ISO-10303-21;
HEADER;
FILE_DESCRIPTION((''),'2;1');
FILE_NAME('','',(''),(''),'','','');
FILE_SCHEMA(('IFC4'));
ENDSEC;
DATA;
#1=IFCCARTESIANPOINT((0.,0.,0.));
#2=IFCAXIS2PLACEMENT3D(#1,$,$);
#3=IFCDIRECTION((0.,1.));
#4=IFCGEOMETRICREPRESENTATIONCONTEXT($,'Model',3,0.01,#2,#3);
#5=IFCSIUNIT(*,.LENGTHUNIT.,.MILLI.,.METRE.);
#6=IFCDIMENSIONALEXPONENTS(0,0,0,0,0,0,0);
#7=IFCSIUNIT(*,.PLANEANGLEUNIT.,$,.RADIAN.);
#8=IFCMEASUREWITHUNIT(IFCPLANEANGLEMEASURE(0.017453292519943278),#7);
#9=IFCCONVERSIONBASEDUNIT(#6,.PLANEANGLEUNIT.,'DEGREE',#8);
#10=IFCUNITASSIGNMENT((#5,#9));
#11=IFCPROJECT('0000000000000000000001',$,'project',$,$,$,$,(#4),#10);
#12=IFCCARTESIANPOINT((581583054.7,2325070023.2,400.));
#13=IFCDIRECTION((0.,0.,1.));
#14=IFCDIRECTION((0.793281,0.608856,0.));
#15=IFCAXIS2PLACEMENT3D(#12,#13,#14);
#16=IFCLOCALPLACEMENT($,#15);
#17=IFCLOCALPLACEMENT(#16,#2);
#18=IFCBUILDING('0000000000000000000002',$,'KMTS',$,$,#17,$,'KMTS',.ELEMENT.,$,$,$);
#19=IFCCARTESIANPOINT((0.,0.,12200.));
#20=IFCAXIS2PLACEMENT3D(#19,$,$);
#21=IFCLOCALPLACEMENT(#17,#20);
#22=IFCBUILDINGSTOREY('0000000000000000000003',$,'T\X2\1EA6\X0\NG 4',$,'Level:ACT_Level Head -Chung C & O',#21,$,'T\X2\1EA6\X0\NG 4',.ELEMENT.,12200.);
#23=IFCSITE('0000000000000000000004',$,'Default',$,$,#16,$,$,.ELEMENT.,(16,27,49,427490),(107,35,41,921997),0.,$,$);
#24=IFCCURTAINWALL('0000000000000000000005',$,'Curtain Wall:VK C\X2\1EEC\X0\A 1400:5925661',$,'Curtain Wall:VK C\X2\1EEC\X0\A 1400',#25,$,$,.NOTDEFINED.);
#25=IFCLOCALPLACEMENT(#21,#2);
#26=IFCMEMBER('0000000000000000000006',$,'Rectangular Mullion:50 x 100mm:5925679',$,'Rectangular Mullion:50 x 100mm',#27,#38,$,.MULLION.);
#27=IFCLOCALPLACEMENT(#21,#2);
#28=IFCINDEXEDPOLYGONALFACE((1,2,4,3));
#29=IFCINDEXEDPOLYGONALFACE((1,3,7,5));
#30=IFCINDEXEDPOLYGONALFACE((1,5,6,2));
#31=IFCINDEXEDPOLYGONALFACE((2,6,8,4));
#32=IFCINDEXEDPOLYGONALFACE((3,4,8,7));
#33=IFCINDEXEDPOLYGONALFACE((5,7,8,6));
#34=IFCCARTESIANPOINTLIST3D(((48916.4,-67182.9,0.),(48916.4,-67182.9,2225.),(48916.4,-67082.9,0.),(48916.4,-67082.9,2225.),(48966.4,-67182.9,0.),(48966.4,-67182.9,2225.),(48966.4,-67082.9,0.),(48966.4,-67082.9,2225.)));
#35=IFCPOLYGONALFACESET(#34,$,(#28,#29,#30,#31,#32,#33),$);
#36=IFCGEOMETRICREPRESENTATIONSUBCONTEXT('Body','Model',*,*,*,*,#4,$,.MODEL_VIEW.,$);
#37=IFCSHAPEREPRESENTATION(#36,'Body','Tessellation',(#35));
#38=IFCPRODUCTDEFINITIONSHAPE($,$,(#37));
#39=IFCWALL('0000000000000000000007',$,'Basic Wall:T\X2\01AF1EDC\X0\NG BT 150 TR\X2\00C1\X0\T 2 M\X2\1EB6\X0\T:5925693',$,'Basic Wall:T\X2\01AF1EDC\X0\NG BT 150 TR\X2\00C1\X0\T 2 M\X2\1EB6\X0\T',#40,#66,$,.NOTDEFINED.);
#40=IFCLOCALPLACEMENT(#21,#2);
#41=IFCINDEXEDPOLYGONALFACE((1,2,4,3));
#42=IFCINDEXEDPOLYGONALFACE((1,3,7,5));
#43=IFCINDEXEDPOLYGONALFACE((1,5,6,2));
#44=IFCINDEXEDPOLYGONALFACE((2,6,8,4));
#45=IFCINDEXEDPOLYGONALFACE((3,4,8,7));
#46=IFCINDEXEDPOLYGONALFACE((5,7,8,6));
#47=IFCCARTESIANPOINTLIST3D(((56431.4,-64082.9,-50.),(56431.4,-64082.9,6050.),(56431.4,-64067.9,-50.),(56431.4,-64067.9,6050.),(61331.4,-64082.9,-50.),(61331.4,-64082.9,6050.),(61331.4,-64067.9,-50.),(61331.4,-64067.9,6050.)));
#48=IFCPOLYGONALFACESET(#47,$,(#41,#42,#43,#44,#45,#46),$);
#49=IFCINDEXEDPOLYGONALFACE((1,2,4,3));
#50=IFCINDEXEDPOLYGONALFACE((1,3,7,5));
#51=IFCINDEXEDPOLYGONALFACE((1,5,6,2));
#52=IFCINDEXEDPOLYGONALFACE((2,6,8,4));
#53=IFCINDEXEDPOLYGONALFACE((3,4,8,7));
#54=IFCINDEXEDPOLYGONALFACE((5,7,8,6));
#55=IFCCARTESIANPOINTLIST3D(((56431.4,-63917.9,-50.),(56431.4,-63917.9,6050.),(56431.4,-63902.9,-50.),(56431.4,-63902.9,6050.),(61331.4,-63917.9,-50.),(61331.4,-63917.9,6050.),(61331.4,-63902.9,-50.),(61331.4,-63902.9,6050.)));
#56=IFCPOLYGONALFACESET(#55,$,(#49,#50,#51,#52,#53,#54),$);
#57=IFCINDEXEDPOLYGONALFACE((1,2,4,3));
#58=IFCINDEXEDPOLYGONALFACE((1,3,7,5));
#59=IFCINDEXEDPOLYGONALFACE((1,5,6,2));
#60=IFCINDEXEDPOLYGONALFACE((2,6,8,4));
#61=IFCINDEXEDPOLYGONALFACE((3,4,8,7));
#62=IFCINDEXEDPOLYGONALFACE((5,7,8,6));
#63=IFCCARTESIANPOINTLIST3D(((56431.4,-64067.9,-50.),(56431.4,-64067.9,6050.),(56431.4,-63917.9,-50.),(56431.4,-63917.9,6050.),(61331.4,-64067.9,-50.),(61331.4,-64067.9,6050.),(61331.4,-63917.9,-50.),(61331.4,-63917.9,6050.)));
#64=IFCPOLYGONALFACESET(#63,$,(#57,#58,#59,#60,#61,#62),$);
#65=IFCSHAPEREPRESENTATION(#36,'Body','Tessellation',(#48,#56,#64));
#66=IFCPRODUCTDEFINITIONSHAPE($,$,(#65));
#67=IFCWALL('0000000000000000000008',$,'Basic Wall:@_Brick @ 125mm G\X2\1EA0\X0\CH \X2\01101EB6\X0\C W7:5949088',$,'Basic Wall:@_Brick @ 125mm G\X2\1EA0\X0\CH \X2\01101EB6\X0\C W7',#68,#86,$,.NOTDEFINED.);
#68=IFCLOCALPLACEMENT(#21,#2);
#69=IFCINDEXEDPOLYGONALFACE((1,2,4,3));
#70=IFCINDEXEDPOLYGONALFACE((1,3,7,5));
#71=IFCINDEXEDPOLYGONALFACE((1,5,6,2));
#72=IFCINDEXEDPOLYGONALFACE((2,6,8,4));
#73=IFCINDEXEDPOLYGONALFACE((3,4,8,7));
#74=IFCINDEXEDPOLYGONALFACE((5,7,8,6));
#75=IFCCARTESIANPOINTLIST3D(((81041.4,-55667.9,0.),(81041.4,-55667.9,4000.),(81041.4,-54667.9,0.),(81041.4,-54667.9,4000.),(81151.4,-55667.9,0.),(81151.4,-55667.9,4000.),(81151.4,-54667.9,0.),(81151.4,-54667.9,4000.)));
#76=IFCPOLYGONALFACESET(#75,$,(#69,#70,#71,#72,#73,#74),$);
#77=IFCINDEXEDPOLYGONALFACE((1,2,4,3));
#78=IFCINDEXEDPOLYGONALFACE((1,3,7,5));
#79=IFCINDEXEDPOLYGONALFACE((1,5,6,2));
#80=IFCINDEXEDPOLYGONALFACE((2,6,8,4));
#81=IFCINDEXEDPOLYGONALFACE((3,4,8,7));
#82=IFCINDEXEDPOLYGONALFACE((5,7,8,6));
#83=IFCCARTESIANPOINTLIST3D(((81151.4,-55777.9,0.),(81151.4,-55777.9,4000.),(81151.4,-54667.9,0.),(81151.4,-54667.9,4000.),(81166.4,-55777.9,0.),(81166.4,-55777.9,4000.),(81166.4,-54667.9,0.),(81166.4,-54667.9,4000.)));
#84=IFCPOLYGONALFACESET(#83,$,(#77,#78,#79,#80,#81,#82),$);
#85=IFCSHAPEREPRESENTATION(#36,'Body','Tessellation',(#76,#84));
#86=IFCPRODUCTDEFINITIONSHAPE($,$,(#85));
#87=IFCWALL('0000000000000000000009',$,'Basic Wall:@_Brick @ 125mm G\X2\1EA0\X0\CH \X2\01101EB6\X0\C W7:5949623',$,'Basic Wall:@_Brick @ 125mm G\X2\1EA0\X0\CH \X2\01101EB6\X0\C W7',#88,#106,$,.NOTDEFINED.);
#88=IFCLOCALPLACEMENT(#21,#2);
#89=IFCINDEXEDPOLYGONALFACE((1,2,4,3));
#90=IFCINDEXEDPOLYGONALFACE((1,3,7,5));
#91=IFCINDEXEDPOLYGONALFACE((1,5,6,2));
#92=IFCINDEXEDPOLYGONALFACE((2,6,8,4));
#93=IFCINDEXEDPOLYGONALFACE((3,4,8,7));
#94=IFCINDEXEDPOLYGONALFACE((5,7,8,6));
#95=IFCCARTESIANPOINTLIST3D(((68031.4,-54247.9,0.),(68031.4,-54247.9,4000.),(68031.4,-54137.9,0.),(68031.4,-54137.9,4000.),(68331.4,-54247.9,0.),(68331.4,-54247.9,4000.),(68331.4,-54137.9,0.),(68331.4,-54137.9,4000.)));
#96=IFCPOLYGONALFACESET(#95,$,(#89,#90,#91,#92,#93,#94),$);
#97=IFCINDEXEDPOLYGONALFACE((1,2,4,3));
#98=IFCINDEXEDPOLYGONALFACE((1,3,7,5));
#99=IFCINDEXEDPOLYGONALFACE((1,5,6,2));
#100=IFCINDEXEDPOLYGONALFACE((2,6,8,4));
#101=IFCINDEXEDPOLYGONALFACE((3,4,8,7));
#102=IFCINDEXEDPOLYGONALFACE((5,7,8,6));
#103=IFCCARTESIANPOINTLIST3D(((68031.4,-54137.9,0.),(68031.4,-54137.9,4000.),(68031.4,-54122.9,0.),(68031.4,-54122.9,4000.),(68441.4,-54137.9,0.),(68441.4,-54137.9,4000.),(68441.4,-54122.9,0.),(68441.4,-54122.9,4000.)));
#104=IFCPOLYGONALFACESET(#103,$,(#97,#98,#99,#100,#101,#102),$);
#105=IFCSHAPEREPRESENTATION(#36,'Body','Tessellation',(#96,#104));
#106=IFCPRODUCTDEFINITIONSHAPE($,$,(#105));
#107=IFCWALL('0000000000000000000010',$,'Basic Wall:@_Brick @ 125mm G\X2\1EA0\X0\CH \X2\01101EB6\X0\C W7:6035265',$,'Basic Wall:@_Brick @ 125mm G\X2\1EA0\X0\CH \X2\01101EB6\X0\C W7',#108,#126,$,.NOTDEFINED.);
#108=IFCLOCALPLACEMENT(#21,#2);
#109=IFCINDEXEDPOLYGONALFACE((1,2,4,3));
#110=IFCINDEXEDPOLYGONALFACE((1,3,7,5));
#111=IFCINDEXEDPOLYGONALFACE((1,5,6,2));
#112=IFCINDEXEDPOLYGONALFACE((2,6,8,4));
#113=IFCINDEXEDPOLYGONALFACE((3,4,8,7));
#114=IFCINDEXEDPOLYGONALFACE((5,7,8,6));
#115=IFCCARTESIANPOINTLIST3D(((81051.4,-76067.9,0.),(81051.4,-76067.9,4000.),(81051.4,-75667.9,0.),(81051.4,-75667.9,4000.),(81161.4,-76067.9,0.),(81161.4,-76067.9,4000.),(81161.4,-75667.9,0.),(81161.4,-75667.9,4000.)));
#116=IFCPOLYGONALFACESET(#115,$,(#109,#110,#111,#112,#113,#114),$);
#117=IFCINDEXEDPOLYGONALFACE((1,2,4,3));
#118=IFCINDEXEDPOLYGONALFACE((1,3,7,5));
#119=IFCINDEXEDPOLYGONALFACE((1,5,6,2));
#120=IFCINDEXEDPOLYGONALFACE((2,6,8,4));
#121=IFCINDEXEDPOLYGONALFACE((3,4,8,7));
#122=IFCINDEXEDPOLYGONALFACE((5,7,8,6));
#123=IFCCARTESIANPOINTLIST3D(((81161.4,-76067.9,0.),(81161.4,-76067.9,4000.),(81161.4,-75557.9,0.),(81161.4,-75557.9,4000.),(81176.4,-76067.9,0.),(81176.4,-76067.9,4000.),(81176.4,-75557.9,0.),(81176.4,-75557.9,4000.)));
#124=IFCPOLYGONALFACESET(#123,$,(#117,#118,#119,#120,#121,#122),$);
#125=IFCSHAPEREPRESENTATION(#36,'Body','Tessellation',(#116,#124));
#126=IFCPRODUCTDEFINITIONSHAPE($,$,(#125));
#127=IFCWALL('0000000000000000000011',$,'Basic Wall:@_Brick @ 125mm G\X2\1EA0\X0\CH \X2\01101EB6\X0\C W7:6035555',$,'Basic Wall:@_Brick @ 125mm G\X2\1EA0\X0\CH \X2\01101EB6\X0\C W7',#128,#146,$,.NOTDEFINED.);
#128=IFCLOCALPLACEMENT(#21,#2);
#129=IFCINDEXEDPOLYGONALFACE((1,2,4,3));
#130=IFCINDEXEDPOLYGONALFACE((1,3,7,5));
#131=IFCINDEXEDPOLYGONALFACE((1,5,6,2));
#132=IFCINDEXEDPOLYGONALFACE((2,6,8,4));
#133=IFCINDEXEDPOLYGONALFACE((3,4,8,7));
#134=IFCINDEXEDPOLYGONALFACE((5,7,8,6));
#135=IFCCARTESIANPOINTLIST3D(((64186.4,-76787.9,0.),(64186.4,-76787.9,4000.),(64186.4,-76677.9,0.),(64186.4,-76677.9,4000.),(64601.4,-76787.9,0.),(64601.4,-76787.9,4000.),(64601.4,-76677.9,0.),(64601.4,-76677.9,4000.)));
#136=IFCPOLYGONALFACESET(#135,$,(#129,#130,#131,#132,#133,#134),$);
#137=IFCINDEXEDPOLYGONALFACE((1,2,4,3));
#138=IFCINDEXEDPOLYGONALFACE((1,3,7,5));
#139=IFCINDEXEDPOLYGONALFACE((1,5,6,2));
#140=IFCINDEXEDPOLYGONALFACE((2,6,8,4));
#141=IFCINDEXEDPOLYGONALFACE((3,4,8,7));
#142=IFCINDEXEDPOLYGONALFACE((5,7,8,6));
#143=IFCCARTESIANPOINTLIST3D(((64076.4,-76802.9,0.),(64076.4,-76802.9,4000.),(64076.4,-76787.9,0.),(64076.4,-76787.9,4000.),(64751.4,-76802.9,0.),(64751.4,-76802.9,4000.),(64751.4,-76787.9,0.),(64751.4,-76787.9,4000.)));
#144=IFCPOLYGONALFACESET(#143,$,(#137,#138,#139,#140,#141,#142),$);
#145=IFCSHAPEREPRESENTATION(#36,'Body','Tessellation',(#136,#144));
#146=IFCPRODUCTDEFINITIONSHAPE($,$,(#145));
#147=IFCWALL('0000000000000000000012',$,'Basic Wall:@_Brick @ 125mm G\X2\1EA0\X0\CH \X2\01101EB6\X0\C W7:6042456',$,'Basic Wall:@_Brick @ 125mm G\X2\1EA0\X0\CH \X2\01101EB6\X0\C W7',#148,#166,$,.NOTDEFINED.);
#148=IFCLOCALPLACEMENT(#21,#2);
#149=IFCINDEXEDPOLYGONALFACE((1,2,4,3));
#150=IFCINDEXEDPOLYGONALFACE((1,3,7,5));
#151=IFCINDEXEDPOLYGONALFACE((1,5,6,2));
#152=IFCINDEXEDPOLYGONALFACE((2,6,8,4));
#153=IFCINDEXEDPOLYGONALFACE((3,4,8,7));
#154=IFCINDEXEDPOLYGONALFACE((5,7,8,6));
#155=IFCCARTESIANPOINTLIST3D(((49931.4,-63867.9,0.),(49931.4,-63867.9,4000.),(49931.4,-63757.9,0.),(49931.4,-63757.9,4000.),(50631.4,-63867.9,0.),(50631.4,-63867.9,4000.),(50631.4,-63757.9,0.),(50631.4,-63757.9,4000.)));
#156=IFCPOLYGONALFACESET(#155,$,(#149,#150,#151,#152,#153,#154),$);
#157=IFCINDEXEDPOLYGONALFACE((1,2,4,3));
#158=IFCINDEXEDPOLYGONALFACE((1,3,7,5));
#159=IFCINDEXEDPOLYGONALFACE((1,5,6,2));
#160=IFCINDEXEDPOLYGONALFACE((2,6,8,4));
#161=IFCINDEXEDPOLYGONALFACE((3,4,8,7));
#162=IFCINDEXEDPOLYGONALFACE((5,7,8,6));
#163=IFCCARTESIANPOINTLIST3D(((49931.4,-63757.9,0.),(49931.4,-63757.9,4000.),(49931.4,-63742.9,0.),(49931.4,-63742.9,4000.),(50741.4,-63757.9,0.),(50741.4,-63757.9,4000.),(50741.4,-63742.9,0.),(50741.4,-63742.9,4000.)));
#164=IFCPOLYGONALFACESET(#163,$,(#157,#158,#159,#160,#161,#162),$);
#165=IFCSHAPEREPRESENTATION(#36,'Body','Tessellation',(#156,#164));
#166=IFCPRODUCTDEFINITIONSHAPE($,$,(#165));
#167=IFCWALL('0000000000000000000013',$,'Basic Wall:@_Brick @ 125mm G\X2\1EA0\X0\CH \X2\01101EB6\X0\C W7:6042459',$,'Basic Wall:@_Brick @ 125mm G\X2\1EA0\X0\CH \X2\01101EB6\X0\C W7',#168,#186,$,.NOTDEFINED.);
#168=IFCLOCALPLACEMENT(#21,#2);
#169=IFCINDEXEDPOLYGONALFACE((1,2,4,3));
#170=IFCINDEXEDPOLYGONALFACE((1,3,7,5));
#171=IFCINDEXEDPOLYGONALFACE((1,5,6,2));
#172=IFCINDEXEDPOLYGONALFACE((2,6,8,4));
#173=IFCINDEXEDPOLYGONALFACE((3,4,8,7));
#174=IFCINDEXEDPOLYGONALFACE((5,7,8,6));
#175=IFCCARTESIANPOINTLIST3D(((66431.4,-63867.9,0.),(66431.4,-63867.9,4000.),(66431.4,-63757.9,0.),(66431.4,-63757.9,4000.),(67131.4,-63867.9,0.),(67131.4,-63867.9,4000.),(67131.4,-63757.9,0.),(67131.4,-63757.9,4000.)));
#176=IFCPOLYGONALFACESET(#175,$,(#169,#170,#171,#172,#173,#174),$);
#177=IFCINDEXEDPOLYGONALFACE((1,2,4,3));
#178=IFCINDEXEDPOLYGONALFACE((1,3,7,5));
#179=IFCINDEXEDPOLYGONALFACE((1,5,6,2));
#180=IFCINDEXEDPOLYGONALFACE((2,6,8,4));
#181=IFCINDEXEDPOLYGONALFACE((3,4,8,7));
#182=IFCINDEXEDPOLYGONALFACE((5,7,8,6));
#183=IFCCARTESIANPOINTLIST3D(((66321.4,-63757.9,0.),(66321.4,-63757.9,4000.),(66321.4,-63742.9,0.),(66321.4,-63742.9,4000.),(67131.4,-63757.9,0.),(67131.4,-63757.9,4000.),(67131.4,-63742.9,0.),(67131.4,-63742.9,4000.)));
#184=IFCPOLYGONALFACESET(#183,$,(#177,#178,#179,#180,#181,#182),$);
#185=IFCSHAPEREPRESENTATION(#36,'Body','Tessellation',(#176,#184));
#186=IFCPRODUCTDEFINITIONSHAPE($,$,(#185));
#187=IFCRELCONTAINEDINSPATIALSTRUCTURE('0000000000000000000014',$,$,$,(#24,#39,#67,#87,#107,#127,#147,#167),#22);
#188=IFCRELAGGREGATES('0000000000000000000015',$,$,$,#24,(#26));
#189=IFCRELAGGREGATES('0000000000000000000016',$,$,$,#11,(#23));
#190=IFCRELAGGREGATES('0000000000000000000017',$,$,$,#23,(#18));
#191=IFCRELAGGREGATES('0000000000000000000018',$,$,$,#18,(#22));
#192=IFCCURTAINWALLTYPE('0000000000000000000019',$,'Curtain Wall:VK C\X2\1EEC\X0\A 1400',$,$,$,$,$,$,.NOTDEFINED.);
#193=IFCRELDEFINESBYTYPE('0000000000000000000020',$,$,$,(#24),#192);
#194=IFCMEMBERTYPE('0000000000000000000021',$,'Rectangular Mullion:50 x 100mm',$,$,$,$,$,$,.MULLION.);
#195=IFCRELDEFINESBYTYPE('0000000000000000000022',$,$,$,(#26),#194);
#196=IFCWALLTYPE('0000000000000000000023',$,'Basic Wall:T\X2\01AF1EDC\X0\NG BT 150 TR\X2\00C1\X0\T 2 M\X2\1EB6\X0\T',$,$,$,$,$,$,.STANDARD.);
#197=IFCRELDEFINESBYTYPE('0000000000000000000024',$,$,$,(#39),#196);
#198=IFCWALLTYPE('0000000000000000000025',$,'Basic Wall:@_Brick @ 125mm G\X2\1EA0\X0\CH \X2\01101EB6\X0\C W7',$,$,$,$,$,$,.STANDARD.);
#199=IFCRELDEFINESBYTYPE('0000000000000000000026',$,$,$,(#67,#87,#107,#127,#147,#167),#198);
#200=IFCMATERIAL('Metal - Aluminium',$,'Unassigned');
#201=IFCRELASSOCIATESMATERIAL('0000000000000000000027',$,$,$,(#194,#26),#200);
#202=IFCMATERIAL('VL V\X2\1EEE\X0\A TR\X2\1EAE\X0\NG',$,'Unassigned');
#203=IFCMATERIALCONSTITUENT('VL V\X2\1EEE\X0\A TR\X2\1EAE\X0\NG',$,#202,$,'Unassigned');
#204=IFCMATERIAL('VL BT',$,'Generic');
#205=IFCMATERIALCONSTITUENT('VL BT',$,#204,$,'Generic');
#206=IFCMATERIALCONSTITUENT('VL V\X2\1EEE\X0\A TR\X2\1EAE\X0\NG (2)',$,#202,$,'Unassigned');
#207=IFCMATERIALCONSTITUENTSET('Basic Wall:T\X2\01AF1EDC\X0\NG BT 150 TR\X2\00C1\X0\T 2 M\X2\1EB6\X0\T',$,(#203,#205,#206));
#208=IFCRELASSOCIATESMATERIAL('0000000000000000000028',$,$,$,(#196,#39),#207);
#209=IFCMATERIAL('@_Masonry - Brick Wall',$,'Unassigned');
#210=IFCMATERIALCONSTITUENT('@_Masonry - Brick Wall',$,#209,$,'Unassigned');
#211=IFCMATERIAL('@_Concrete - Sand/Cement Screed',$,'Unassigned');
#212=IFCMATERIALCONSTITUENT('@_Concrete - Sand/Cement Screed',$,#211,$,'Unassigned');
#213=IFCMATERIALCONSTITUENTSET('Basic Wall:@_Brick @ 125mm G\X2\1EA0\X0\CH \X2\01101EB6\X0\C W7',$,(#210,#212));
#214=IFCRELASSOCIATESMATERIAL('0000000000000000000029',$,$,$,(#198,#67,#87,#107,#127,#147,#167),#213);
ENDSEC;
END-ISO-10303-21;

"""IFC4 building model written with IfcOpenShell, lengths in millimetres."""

from ifc_helpers import new_model, entity, si_unit, converted_unit, direction, frame, origin, place, context, subcontext, project, spatial, indexed_curve, outline, extrude, source, transform, mapped, material, constituent, constituent_set, type_object, type_shapes, element, aggregate, save


model = new_model("IFC4")

# Units and contexts
model_context = context("Model", 3, precision=0.01, world=origin(), true_north=direction((0.0, 1.0)))
body_context = subcontext(model_context, "Body", "Model", "MODEL_VIEW")
ifc_project = project(units=[si_unit("LENGTHUNIT", "METRE", prefix="MILLI"), converted_unit("PLANEANGLEUNIT", "DEGREE", entity("IfcPlaneAngleMeasure", 0.017453292519943278), si_unit("PLANEANGLEUNIT", "RADIAN"), dimensions=[0, 0, 0, 0, 0, 0, 0])], contexts=[model_context])

# Site, building, storey
site_placement = place(None, frame((581583054.7, 2325070023.2, 400.0), z_axis=(0.0, 0.0, 1.0), x_axis=(0.793281, 0.608856, 0.0)))
site = spatial("IfcSite", under=ifc_project, at=site_placement, Name="Default", CompositionType="ELEMENT", RefLatitude=(16, 27, 49, 427490), RefLongitude=(107, 35, 41, 921997), RefElevation=0.0)
building_placement = place(site_placement, origin())
building = spatial("IfcBuilding", under=site, at=building_placement, Name="KMTS", LongName="KMTS", CompositionType="ELEMENT")
storey_placement = place(building_placement, frame((0.0, 0.0, 12200.0)))
storey = spatial("IfcBuildingStorey", under=building, at=storey_placement, Name="TẦNG 4", ObjectType="Level:ACT_Level Head -Chung C & O", LongName="TẦNG 4", CompositionType="ELEMENT", Elevation=12200.0)

# Curtain wall, member
curtain_wall_type = type_object("IfcCurtainWallType", Name="Curtain Wall:VK CỬA 1400", PredefinedType="NOTDEFINED")
curtain_wall_placement = place(storey_placement, frame((0.0, 0.0, -12200.0)))
curtain_wall = element("IfcCurtainWall", 1, at=curtain_wall_placement, inside=storey, type_object=curtain_wall_type, Name="Curtain Wall:VK CỬA 1400:5925661", ObjectType="Curtain Wall:VK CỬA 1400", PredefinedType="NOTDEFINED")
ifc_material_1 = material(Name="Metal - Aluminium", Category="Unassigned")
member_type = type_object("IfcMemberType", Name="Rectangular Mullion:50 x 100mm", PredefinedType="MULLION", material=ifc_material_1)
shared_shape = source(origin(), body_context, "Body", "SweptSolid", [
    extrude(outline(indexed_curve([(-25.0, -50.0), (25.0, -50.0), (25.0, 50.0), (-25.0, 50.0), (-25.0, -50.0)], self_intersect=False)), frame((-25.0, 0.0, -2225.0), z_axis=(0.0, 0.0, 1.0), x_axis=(-1.0, 0.0, 0.0)), (0.0, 0.0, 1.0), 2225.0),
])
type_shapes(member_type, [shared_shape])
member_placement = place(curtain_wall_placement, frame((48966.4, -67132.9, 14425.0)))
member = element("IfcMember", 2, at=member_placement, type_object=member_type, material=ifc_material_1, Name="Rectangular Mullion:50 x 100mm:5925679", ObjectType="Rectangular Mullion:50 x 100mm", PredefinedType="MULLION", context=body_context, shape_type="MappedRepresentation", body=[
    mapped(shared_shape, transform((0.0, 0.0, 0.0), scale=1.0)),
])
aggregate(curtain_wall, [member])

# Shared definitions
ifc_material_2 = material(Name="VL VỮA TRẮNG", Category="Unassigned")
ifc_constituent_1 = constituent(ifc_material_2, Name="VL VỮA TRẮNG", Category="Unassigned")
ifc_material_3 = material(Name="VL BT", Category="Generic")
ifc_constituent_2 = constituent(ifc_material_3, Name="VL BT", Category="Generic")
ifc_constituent_3 = constituent(ifc_material_2, Name="VL VỮA TRẮNG (2)", Category="Unassigned")
ifc_constituent_set_1 = constituent_set(constituents=[ifc_constituent_1, ifc_constituent_2, ifc_constituent_3], Name="Basic Wall:TƯỜNG BT 150 TRÁT 2 MẶT")
wall_type_1 = type_object("IfcWallType", Name="Basic Wall:TƯỜNG BT 150 TRÁT 2 MẶT", PredefinedType="STANDARD", material=ifc_constituent_set_1)

# Wall
wall_1_placement = place(storey_placement, frame((61331.4, -63992.9, -50.0), z_axis=(0.0, 0.0, 1.0), x_axis=(-1.0, 0.0, 0.0)))
element("IfcWall", 3, at=wall_1_placement, inside=storey, type_object=wall_type_1, material=ifc_constituent_set_1, Name="Basic Wall:TƯỜNG BT 150 TRÁT 2 MẶT:5925693", ObjectType="Basic Wall:TƯỜNG BT 150 TRÁT 2 MẶT", PredefinedType="NOTDEFINED", context=body_context, shape_type="SweptSolid", body=[
    extrude(outline(indexed_curve([(-7.5, -2450.0), (7.5, -2450.0), (7.5, 2450.0), (-7.5, 2450.0), (-7.5, -2450.0)], self_intersect=False)), frame((2450.0, 82.5, 0.0), z_axis=(0.0, 0.0, 1.0), x_axis=(0.0, -1.0, 0.0)), (0.0, 0.0, 1.0), 6100.0),
    extrude(outline(indexed_curve([(-7.5, -2450.0), (7.5, -2450.0), (7.5, 2450.0), (-7.5, 2450.0), (-7.5, -2450.0)], self_intersect=False)), frame((2450.0, -82.5, 0.0), z_axis=(0.0, 0.0, 1.0), x_axis=(0.0, 1.0, 0.0)), (0.0, 0.0, 1.0), 6100.0),
    extrude(outline(indexed_curve([(-2450.0, -75.0), (2450.0, -75.0), (2450.0, 75.0), (-2450.0, 75.0), (-2450.0, -75.0)], self_intersect=False)), frame((2450.0, 0.0, 0.0)), (0.0, 0.0, 1.0), 6100.0),
])

# Walls
ifc_material_4 = material(Name="@_Masonry - Brick Wall", Category="Unassigned")
ifc_constituent_4 = constituent(ifc_material_4, Name="@_Masonry - Brick Wall", Category="Unassigned")
ifc_material_5 = material(Name="@_Concrete - Sand/Cement Screed", Category="Unassigned")
ifc_constituent_5 = constituent(ifc_material_5, Name="@_Concrete - Sand/Cement Screed", Category="Unassigned")
ifc_constituent_set_2 = constituent_set(constituents=[ifc_constituent_4, ifc_constituent_5], Name="Basic Wall:@_Brick @ 125mm GẠCH ĐẶC W7")
wall_type_2 = type_object("IfcWallType", Name="Basic Wall:@_Brick @ 125mm GẠCH ĐẶC W7", PredefinedType="STANDARD", material=ifc_constituent_set_2)
wall_2_placement = place(storey_placement, frame((81103.9, -55667.9, 0.0), z_axis=(0.0, 0.0, 1.0), x_axis=(0.0, 1.0, 0.0)))
element("IfcWall", 4, at=wall_2_placement, inside=storey, type_object=wall_type_2, material=ifc_constituent_set_2, Name="Basic Wall:@_Brick @ 125mm GẠCH ĐẶC W7:5949088", ObjectType="Basic Wall:@_Brick @ 125mm GẠCH ĐẶC W7", PredefinedType="NOTDEFINED", context=body_context, shape_type="SweptSolid", body=[
    extrude(outline(indexed_curve([(-55.0, -500.0), (55.0, -500.0), (55.0, 500.0), (-55.0, 500.0), (-55.0, -500.0)], self_intersect=False)), frame((500.0, 7.5, 0.0), z_axis=(0.0, 0.0, 1.0), x_axis=(0.0, -1.0, 0.0)), (0.0, 0.0, 1.0), 4000.0),
    extrude(outline(indexed_curve([(-7.5, -555.0), (7.5, -555.0), (7.5, 555.0), (-7.5, 555.0), (-7.5, -555.0)], self_intersect=False)), frame((445.0, -55.0, 0.0), z_axis=(0.0, 0.0, 1.0), x_axis=(0.0, 1.0, 0.0)), (0.0, 0.0, 1.0), 4000.0),
])
wall_3_placement = place(storey_placement, frame((68331.4, -54185.4, 0.0), z_axis=(0.0, 0.0, 1.0), x_axis=(-1.0, 0.0, 0.0)))
element("IfcWall", 5, at=wall_3_placement, inside=storey, type_object=wall_type_2, material=ifc_constituent_set_2, Name="Basic Wall:@_Brick @ 125mm GẠCH ĐẶC W7:5949623", ObjectType="Basic Wall:@_Brick @ 125mm GẠCH ĐẶC W7", PredefinedType="NOTDEFINED", context=body_context, shape_type="SweptSolid", body=[
    extrude(outline(indexed_curve([(-55.0, -150.0), (55.0, -150.0), (55.0, 150.0), (-55.0, 150.0), (-55.0, -150.0)], self_intersect=False)), frame((150.0, 7.5, 0.0), z_axis=(0.0, 0.0, 1.0), x_axis=(0.0, -1.0, 0.0)), (0.0, 0.0, 1.0), 4000.0),
    extrude(outline(indexed_curve([(-7.5, -205.0), (7.5, -205.0), (7.5, 205.0), (-7.5, 205.0), (-7.5, -205.0)], self_intersect=False)), frame((95.0, -55.0, 0.0), z_axis=(0.0, 0.0, 1.0), x_axis=(0.0, 1.0, 0.0)), (0.0, 0.0, 1.0), 4000.0),
])
wall_4_placement = place(storey_placement, frame((81113.9, -76067.9, 0.0), z_axis=(0.0, 0.0, 1.0), x_axis=(0.0, 1.0, 0.0)))
element("IfcWall", 6, at=wall_4_placement, inside=storey, type_object=wall_type_2, material=ifc_constituent_set_2, Name="Basic Wall:@_Brick @ 125mm GẠCH ĐẶC W7:6035265", ObjectType="Basic Wall:@_Brick @ 125mm GẠCH ĐẶC W7", PredefinedType="NOTDEFINED", context=body_context, shape_type="SweptSolid", body=[
    extrude(outline(indexed_curve([(-55.0, -200.0), (55.0, -200.0), (55.0, 200.0), (-55.0, 200.0), (-55.0, -200.0)], self_intersect=False)), frame((200.0, 7.5, 0.0), z_axis=(0.0, 0.0, 1.0), x_axis=(0.0, -1.0, 0.0)), (0.0, 0.0, 1.0), 4000.0),
    extrude(outline(indexed_curve([(-7.5, -255.0), (7.5, -255.0), (7.5, 255.0), (-7.5, 255.0), (-7.5, -255.0)], self_intersect=False)), frame((255.0, -55.0, 0.0), z_axis=(0.0, 0.0, 1.0), x_axis=(0.0, 1.0, 0.0)), (0.0, 0.0, 1.0), 4000.0),
])
wall_5_placement = place(storey_placement, frame((64186.4, -76740.4, 0.0)))
element("IfcWall", 7, at=wall_5_placement, inside=storey, type_object=wall_type_2, material=ifc_constituent_set_2, Name="Basic Wall:@_Brick @ 125mm GẠCH ĐẶC W7:6035555", ObjectType="Basic Wall:@_Brick @ 125mm GẠCH ĐẶC W7", PredefinedType="NOTDEFINED", context=body_context, shape_type="SweptSolid", body=[
    extrude(outline(indexed_curve([(-55.0, -207.5), (55.0, -207.5), (55.0, 207.5), (-55.0, 207.5), (-55.0, -207.5)], self_intersect=False)), frame((207.5, 7.5, 0.0), z_axis=(0.0, 0.0, 1.0), x_axis=(0.0, -1.0, 0.0)), (0.0, 0.0, 1.0), 4000.0),
    extrude(outline(indexed_curve([(-7.5, -337.5), (7.5, -337.5), (7.5, 337.5), (-7.5, 337.5), (-7.5, -337.5)], self_intersect=False)), frame((227.5, -55.0, 0.0), z_axis=(0.0, 0.0, 1.0), x_axis=(0.0, 1.0, 0.0)), (0.0, 0.0, 1.0), 4000.0),
])
wall_6_placement = place(storey_placement, frame((50631.4, -63805.4, 0.0), z_axis=(0.0, 0.0, 1.0), x_axis=(-1.0, 0.0, 0.0)))
element("IfcWall", 8, at=wall_6_placement, inside=storey, type_object=wall_type_2, material=ifc_constituent_set_2, Name="Basic Wall:@_Brick @ 125mm GẠCH ĐẶC W7:6042456", ObjectType="Basic Wall:@_Brick @ 125mm GẠCH ĐẶC W7", PredefinedType="NOTDEFINED", context=body_context, shape_type="SweptSolid", body=[
    extrude(outline(indexed_curve([(-55.0, -350.0), (55.0, -350.0), (55.0, 350.0), (-55.0, 350.0), (-55.0, -350.0)], self_intersect=False)), frame((350.0, 7.5, 0.0), z_axis=(0.0, 0.0, 1.0), x_axis=(0.0, -1.0, 0.0)), (0.0, 0.0, 1.0), 4000.0),
    extrude(outline(indexed_curve([(-7.5, -405.0), (7.5, -405.0), (7.5, 405.0), (-7.5, 405.0), (-7.5, -405.0)], self_intersect=False)), frame((295.0, -55.0, 0.0), z_axis=(0.0, 0.0, 1.0), x_axis=(0.0, 1.0, 0.0)), (0.0, 0.0, 1.0), 4000.0),
])
wall_7_placement = place(storey_placement, frame((66431.4, -63805.4, 0.0)))
element("IfcWall", 9, at=wall_7_placement, inside=storey, type_object=wall_type_2, material=ifc_constituent_set_2, Name="Basic Wall:@_Brick @ 125mm GẠCH ĐẶC W7:6042459", ObjectType="Basic Wall:@_Brick @ 125mm GẠCH ĐẶC W7", PredefinedType="NOTDEFINED", context=body_context, shape_type="SweptSolid", body=[
    extrude(outline(indexed_curve([(-55.0, -350.0), (55.0, -350.0), (55.0, 350.0), (-55.0, 350.0), (-55.0, -350.0)], self_intersect=False)), frame((350.0, -7.5, 0.0), z_axis=(0.0, 0.0, 1.0), x_axis=(0.0, 1.0, 0.0)), (0.0, 0.0, 1.0), 4000.0),
    extrude(outline(indexed_curve([(-7.5, -405.0), (7.5, -405.0), (7.5, 405.0), (-7.5, 405.0), (-7.5, -405.0)], self_intersect=False)), frame((295.0, 55.0, 0.0), z_axis=(0.0, 0.0, 1.0), x_axis=(0.0, -1.0, 0.0)), (0.0, 0.0, 1.0), 4000.0),
])

save(model, "model.ifc")
